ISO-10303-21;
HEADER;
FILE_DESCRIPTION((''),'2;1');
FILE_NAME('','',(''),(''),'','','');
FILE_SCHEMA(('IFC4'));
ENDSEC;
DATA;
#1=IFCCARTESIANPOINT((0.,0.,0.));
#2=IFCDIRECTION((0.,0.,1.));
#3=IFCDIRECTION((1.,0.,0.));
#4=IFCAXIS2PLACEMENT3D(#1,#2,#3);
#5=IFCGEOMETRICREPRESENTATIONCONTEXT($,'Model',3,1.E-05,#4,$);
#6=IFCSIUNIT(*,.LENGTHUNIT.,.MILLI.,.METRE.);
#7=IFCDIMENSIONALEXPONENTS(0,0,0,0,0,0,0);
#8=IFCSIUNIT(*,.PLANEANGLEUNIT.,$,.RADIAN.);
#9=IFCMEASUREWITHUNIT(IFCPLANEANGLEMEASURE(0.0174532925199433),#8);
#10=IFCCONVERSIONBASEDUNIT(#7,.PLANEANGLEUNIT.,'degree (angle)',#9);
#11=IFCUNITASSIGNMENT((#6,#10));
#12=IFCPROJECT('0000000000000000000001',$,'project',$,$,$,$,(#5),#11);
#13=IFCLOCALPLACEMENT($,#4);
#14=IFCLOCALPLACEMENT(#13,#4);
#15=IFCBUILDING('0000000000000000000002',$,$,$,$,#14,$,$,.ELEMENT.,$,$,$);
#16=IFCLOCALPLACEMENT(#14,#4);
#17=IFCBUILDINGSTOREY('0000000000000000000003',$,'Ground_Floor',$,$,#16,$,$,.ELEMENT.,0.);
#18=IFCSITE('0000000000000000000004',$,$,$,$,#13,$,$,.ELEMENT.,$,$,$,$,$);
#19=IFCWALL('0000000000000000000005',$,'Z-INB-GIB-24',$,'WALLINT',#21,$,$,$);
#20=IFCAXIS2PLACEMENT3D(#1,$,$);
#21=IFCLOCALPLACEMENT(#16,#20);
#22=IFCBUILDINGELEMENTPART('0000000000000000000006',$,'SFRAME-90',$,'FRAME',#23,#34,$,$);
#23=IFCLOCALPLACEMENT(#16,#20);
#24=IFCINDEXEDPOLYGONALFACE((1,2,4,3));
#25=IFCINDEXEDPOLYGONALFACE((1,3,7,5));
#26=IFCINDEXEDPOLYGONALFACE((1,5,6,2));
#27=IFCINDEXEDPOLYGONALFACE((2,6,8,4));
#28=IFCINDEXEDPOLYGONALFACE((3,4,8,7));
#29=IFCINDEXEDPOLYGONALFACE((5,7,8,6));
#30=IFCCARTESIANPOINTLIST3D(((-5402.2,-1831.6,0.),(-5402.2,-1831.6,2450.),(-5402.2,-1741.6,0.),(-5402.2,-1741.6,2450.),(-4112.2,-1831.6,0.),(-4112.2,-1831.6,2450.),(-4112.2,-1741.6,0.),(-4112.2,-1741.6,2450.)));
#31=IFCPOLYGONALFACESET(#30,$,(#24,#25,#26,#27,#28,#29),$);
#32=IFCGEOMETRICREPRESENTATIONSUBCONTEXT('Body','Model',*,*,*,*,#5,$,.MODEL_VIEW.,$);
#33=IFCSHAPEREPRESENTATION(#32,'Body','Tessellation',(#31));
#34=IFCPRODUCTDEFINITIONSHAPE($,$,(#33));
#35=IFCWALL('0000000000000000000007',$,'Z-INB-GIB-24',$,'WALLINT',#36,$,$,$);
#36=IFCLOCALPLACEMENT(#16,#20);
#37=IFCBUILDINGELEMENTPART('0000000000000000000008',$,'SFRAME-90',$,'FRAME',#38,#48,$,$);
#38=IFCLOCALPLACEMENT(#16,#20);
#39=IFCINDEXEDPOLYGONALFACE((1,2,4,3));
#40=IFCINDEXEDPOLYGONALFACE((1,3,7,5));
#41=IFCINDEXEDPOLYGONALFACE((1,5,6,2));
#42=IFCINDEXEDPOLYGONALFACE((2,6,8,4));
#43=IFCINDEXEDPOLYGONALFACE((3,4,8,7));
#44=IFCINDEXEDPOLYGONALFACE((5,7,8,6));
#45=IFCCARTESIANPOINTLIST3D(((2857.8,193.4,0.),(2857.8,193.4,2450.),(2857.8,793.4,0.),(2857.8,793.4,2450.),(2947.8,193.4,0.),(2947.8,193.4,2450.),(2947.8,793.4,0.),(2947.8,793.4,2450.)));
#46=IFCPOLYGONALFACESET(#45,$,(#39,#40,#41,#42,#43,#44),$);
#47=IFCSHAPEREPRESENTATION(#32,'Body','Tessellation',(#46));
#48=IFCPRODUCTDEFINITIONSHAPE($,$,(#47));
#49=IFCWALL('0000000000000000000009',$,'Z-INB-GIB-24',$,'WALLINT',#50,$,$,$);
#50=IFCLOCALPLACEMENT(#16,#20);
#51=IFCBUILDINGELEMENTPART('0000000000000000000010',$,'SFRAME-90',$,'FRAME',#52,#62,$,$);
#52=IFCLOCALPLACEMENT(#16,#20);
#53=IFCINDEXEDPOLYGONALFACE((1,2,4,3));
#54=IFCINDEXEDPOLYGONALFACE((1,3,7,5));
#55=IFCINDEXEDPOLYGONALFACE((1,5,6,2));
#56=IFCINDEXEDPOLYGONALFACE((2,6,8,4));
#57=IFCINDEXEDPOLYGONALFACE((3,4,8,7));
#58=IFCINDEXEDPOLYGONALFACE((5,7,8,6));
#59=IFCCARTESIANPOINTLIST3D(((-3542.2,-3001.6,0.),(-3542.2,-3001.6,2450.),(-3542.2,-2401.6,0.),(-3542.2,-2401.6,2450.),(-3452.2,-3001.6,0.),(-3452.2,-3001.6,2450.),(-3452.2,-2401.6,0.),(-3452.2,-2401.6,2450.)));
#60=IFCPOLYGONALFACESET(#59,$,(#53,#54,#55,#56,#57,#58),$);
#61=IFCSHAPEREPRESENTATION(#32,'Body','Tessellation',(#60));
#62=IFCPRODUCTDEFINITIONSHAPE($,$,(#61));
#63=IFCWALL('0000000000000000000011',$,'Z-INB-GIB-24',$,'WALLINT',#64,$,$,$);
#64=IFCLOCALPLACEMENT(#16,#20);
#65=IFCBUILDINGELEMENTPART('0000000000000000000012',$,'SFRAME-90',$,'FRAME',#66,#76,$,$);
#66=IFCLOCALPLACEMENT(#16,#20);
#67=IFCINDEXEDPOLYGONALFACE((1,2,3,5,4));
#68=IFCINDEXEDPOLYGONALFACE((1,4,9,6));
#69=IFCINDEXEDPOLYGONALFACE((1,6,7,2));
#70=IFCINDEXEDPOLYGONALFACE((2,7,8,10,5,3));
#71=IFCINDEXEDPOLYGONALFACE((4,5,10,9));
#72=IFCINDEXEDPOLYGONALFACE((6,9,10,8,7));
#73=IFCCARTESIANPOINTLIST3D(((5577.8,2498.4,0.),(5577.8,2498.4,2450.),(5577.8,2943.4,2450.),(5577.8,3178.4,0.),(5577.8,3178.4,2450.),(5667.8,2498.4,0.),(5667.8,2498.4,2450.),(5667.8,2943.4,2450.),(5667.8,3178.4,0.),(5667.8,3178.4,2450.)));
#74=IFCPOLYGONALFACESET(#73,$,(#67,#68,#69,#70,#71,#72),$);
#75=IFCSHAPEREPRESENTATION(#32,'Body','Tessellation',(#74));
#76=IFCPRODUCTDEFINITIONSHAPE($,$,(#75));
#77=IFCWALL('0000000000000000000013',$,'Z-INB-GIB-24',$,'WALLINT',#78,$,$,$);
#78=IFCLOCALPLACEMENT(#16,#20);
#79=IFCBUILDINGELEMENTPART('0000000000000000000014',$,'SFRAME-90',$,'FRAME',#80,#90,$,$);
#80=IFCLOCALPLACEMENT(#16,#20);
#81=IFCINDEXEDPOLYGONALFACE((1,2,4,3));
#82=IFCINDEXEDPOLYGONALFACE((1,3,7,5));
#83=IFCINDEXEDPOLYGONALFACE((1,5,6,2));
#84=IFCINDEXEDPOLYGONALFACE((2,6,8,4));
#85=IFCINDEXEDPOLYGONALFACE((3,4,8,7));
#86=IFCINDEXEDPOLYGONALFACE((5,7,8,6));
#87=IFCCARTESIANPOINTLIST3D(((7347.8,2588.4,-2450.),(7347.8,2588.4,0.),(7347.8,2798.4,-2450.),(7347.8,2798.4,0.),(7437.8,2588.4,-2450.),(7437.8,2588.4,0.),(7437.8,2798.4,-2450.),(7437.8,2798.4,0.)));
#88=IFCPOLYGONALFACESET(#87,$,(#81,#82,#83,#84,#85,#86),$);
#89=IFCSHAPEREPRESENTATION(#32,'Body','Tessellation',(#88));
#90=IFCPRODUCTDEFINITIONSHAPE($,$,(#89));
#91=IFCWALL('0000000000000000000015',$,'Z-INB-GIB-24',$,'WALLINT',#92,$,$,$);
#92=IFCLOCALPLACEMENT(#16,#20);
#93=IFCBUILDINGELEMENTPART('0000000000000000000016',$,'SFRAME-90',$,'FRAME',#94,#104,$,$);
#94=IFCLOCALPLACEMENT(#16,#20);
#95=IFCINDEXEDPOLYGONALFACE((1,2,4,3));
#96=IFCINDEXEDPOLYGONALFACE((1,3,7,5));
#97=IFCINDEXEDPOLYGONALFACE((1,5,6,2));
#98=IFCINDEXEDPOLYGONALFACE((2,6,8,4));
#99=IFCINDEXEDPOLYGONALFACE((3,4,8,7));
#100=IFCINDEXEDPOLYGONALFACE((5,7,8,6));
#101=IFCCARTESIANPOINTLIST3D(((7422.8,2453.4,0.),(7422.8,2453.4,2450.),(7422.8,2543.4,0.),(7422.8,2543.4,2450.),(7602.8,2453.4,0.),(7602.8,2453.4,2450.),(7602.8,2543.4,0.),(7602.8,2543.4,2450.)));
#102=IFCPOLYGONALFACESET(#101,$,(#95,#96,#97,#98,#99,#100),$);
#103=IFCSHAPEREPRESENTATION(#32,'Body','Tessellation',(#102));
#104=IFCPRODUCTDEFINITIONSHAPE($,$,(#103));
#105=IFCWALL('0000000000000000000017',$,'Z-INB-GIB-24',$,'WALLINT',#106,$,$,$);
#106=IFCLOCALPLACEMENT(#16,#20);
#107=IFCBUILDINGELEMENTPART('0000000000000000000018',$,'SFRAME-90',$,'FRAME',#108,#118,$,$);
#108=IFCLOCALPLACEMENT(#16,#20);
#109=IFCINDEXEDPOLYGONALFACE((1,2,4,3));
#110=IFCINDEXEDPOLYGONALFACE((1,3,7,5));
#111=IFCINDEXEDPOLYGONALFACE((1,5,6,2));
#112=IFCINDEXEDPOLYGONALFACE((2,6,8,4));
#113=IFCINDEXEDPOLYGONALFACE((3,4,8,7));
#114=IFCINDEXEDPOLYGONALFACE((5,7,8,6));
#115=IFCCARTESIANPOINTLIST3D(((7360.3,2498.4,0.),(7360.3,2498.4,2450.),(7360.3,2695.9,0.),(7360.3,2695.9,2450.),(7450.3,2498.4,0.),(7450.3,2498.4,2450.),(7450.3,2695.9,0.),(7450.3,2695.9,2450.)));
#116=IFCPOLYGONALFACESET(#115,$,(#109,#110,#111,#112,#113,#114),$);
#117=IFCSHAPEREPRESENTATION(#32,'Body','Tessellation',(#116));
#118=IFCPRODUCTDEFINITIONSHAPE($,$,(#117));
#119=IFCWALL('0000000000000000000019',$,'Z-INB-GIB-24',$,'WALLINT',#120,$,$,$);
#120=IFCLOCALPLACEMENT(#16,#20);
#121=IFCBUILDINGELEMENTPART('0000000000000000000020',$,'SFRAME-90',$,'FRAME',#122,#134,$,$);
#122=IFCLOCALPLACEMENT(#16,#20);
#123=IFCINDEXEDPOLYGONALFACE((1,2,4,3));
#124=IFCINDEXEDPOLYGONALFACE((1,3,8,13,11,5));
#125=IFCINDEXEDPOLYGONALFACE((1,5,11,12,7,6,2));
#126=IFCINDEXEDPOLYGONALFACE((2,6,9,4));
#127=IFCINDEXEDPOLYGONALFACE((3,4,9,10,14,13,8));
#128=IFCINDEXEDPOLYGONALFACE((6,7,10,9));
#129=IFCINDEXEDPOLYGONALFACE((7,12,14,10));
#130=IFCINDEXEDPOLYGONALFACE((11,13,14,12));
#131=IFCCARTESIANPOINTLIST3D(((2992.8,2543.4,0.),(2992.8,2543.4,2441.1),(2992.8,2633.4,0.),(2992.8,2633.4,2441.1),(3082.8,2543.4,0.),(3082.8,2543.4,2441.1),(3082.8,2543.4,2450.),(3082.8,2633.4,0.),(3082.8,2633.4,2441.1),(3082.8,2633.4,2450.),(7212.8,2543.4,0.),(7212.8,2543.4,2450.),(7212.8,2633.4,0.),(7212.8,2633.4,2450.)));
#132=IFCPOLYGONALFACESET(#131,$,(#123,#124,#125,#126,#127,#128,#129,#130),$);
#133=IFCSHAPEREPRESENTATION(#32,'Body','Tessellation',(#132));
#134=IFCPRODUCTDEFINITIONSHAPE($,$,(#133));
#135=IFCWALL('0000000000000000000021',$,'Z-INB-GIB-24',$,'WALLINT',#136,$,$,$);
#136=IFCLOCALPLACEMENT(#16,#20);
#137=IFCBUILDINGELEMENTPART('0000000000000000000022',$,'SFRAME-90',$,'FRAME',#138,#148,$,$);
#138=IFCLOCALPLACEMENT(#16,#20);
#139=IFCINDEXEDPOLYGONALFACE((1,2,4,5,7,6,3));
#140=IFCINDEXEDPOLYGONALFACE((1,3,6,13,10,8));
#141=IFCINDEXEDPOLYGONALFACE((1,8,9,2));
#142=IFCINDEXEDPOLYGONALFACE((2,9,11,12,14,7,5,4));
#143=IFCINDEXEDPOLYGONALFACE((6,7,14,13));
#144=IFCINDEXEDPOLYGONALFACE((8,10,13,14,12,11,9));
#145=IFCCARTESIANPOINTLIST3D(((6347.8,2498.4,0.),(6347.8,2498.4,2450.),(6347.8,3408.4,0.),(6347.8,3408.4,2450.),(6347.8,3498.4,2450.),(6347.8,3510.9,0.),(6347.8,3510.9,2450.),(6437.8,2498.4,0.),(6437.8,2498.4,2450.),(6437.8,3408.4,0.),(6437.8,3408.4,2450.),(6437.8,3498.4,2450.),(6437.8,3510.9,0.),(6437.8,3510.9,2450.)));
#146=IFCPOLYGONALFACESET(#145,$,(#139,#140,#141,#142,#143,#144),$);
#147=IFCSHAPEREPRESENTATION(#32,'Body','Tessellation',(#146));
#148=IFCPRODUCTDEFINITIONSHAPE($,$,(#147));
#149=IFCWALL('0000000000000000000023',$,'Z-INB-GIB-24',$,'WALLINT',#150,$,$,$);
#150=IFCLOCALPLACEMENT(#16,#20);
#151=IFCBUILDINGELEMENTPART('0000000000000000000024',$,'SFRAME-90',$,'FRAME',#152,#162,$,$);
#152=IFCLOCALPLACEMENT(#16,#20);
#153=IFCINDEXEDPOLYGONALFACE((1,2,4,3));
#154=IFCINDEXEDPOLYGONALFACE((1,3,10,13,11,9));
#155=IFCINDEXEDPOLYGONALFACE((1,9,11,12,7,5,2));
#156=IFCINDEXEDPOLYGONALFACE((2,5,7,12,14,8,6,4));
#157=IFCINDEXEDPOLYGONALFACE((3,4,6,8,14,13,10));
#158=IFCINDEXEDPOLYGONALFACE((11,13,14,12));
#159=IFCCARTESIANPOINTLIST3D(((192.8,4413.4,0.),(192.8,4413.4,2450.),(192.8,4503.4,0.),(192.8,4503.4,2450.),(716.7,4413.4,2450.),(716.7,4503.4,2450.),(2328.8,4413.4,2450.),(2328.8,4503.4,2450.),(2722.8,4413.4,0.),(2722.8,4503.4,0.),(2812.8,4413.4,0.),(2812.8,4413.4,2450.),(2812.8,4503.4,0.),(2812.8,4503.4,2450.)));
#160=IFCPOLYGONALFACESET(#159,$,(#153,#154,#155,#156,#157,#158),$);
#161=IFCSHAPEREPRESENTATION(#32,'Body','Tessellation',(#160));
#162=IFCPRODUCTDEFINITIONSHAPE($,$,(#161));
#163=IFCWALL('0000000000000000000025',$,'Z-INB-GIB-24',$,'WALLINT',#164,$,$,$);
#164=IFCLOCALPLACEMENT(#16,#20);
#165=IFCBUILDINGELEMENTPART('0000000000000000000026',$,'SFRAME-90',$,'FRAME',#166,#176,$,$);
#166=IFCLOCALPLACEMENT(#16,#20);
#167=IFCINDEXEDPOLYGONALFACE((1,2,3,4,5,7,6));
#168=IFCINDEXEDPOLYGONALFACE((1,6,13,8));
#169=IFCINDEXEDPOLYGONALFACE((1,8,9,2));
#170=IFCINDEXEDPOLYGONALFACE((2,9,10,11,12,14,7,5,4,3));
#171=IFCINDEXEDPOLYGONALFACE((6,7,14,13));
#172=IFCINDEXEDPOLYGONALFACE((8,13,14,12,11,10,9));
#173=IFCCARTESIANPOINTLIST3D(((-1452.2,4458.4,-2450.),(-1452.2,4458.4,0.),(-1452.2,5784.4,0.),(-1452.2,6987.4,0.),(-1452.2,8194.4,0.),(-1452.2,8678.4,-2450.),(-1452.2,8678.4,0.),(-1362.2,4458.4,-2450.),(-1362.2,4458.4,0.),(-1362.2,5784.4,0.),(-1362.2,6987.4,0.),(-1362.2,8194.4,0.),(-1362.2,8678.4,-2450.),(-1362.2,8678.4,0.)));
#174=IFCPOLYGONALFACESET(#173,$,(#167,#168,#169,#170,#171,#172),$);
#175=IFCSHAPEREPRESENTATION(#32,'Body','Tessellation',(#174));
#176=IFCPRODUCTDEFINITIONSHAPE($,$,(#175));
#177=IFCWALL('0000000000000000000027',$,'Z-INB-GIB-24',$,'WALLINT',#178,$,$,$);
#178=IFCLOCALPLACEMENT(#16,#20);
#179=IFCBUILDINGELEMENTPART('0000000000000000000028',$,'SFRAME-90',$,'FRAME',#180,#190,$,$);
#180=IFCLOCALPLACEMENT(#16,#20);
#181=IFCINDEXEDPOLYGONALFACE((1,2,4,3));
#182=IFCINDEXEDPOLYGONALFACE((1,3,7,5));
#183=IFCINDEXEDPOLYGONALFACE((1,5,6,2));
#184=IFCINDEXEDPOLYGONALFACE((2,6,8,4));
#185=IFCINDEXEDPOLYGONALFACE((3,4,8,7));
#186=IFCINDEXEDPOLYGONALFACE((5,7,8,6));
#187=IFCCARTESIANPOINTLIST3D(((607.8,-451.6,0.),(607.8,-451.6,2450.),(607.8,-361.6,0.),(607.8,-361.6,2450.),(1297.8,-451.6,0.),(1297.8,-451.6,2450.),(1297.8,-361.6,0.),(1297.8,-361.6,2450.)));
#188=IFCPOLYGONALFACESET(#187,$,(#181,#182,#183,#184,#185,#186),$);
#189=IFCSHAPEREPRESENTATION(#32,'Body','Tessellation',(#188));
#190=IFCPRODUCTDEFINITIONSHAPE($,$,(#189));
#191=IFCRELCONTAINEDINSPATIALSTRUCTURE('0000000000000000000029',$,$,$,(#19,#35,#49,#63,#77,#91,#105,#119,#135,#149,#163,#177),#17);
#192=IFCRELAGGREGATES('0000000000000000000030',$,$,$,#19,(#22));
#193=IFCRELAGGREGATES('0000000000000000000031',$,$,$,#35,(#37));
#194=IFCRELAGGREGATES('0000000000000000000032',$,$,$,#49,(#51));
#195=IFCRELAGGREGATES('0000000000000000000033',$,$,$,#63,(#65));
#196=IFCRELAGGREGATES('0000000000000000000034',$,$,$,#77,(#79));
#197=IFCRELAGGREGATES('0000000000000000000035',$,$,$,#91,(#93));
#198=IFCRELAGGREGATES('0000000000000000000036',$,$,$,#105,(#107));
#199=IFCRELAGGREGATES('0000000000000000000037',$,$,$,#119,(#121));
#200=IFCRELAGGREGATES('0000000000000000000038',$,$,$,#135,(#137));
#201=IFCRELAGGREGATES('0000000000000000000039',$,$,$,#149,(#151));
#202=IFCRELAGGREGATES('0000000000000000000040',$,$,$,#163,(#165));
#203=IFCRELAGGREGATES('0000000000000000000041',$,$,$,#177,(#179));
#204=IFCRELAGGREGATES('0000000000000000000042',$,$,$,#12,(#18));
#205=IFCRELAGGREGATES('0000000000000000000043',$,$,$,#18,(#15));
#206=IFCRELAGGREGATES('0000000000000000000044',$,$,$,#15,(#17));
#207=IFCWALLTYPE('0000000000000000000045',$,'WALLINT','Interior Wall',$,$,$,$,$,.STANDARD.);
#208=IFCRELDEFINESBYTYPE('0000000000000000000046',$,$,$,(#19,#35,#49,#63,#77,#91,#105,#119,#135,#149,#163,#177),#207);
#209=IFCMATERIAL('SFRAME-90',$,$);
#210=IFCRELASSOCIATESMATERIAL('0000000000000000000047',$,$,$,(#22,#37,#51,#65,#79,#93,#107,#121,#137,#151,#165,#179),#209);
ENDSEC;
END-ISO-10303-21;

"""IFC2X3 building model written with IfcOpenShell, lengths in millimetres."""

from ifc_helpers import new_model, entity, si_unit, converted_unit, frame, origin_with_axes, place, context, subcontext, project, spatial, polyline, segment, composite_curve, outline, extrude, material, type_object, element, aggregate, save


model = new_model("IFC2X3")

# Units and contexts
model_context = context("Model", 3, precision=1e-05, world=origin_with_axes())
body_context = subcontext(model_context, "Body", "Model", "MODEL_VIEW")
ifc_project = project(units=[si_unit("LENGTHUNIT", "METRE", prefix="MILLI"), converted_unit("PLANEANGLEUNIT", "degree (angle)", entity("IfcPlaneAngleMeasure", 0.0174532925199433), si_unit("PLANEANGLEUNIT", "RADIAN"), dimensions=[0, 0, 0, 0, 0, 0, 0])], contexts=[model_context])

# Site, building, storey
site_placement = place(None, origin_with_axes())
site = spatial("IfcSite", under=ifc_project, at=site_placement, CompositionType="ELEMENT")
building_placement = place(site_placement, origin_with_axes())
building = spatial("IfcBuilding", under=site, at=building_placement, CompositionType="ELEMENT")
storey_placement = place(building_placement, origin_with_axes())
storey = spatial("IfcBuildingStorey", under=building, at=storey_placement, Name="Ground_Floor", CompositionType="ELEMENT", Elevation=0.0)

# Walls, building element parts
wall_type = type_object("IfcWallType", Name="WALLINT", Description="Interior Wall", PredefinedType="STANDARD")
ifc_material = material(Name="SFRAME-90")
wall_1_placement = place(storey_placement, frame((-4112.2, -1786.6, 2450.0), z_axis=(0.0, 0.0, 1.0), x_axis=(-1.0, 0.0, 0.0)))
wall_1 = element("IfcWall", 1, at=wall_1_placement, inside=storey, type_object=wall_type, Name="Z-INB-GIB-24", ObjectType="WALLINT")
building_element_part_1_placement = place(wall_1_placement, origin_with_axes())
building_element_part_1 = element("IfcBuildingElementPart", 2, at=building_element_part_1_placement, material=ifc_material, Name="SFRAME-90", ObjectType="FRAME", context=body_context, shape_type="SweptSolid", body=[
    extrude(outline(composite_curve([segment(polyline([(0.0, 2450.0), (0.0, 0.0), (1290.0, 0.0), (1290.0, 2450.0), (0.0, 2450.0)]), True, "CONTINUOUS")], self_intersect=False)), frame((0.0, -45.0, 0.0), z_axis=(0.0, 1.0, 0.0), x_axis=(1.0, 0.0, 0.0)), (0.0, 0.0, 1.0), 90.0),
])
aggregate(wall_1, [building_element_part_1])
wall_2_placement = place(storey_placement, frame((2902.8, 193.4, 2450.0), z_axis=(0.0, 0.0, 1.0), x_axis=(0.0, 1.0, 0.0)))
wall_2 = element("IfcWall", 3, at=wall_2_placement, inside=storey, type_object=wall_type, Name="Z-INB-GIB-24", ObjectType="WALLINT")
building_element_part_2_placement = place(wall_2_placement, origin_with_axes())
building_element_part_2 = element("IfcBuildingElementPart", 4, at=building_element_part_2_placement, material=ifc_material, Name="SFRAME-90", ObjectType="FRAME", context=body_context, shape_type="SweptSolid", body=[
    extrude(outline(composite_curve([segment(polyline([(0.0, 0.0), (600.0, 0.0), (600.0, 2450.0), (0.0, 2450.0), (0.0, 0.0)]), True, "CONTINUOUS")], self_intersect=False)), frame((0.0, -45.0, 0.0), z_axis=(0.0, 1.0, 0.0), x_axis=(1.0, 0.0, 0.0)), (0.0, 0.0, 1.0), 90.0),
])
aggregate(wall_2, [building_element_part_2])
wall_3_placement = place(storey_placement, frame((-3497.2, -3001.6, 2450.0), z_axis=(0.0, 0.0, 1.0), x_axis=(0.0, 1.0, 0.0)))
wall_3 = element("IfcWall", 5, at=wall_3_placement, inside=storey, type_object=wall_type, Name="Z-INB-GIB-24", ObjectType="WALLINT")
building_element_part_3_placement = place(wall_3_placement, origin_with_axes())
building_element_part_3 = element("IfcBuildingElementPart", 6, at=building_element_part_3_placement, material=ifc_material, Name="SFRAME-90", ObjectType="FRAME", context=body_context, shape_type="SweptSolid", body=[
    extrude(outline(composite_curve([segment(polyline([(0.0, 0.0), (600.0, 0.0), (600.0, 2450.0), (0.0, 2450.0), (0.0, 0.0)]), True, "CONTINUOUS")], self_intersect=False)), frame((0.0, -45.0, 0.0), z_axis=(0.0, 1.0, 0.0), x_axis=(1.0, 0.0, 0.0)), (0.0, 0.0, 1.0), 90.0),
])
aggregate(wall_3, [building_element_part_3])
wall_4_placement = place(storey_placement, frame((5622.8, 2498.4, 2450.0), z_axis=(0.0, 0.0, 1.0), x_axis=(0.0, 1.0, 0.0)))
wall_4 = element("IfcWall", 7, at=wall_4_placement, inside=storey, type_object=wall_type, Name="Z-INB-GIB-24", ObjectType="WALLINT")
building_element_part_4_placement = place(wall_4_placement, origin_with_axes())
building_element_part_4 = element("IfcBuildingElementPart", 8, at=building_element_part_4_placement, material=ifc_material, Name="SFRAME-90", ObjectType="FRAME", context=body_context, shape_type="SweptSolid", body=[
    extrude(outline(composite_curve([segment(polyline([(0.0, 0.0), (0.0, 2450.0), (680.0, 2450.0), (680.0, 0.0), (445.0, 0.0), (0.0, 0.0)]), True, "CONTINUOUS")], self_intersect=False)), frame((0.0, -45.0, 0.0), z_axis=(0.0, 1.0, 0.0), x_axis=(1.0, 0.0, 0.0)), (0.0, 0.0, 1.0), 90.0),
])
aggregate(wall_4, [building_element_part_4])
wall_5_placement = place(storey_placement, frame((7392.8, 2588.4, 0.0), z_axis=(0.0, 0.0, 1.0), x_axis=(0.0, 1.0, 0.0)))
wall_5 = element("IfcWall", 9, at=wall_5_placement, inside=storey, type_object=wall_type, Name="Z-INB-GIB-24", ObjectType="WALLINT")
building_element_part_5_placement = place(wall_5_placement, origin_with_axes())
building_element_part_5 = element("IfcBuildingElementPart", 10, at=building_element_part_5_placement, material=ifc_material, Name="SFRAME-90", ObjectType="FRAME", context=body_context, shape_type="SweptSolid", body=[
    extrude(outline(composite_curve([segment(polyline([(0.0, 2450.0), (0.0, 0.0), (210.0, 0.0), (210.0, 2450.0), (0.0, 2450.0)]), True, "CONTINUOUS")], self_intersect=False)), frame((0.0, -45.0, 0.0), z_axis=(0.0, 1.0, 0.0), x_axis=(1.0, 0.0, 0.0)), (0.0, 0.0, 1.0), 90.0),
])
aggregate(wall_5, [building_element_part_5])
wall_6_placement = place(storey_placement, frame((7602.8, 2498.4, 2450.0), z_axis=(0.0, 0.0, 1.0), x_axis=(-1.0, 0.0, 0.0)))
wall_6 = element("IfcWall", 11, at=wall_6_placement, inside=storey, type_object=wall_type, Name="Z-INB-GIB-24", ObjectType="WALLINT")
building_element_part_6_placement = place(wall_6_placement, origin_with_axes())
building_element_part_6 = element("IfcBuildingElementPart", 12, at=building_element_part_6_placement, material=ifc_material, Name="SFRAME-90", ObjectType="FRAME", context=body_context, shape_type="SweptSolid", body=[
    extrude(outline(composite_curve([segment(polyline([(0.0, 2450.0), (0.0, 0.0), (180.0, 0.0), (180.0, 2450.0), (0.0, 2450.0)]), True, "CONTINUOUS")], self_intersect=False)), frame((0.0, -45.0, 0.0), z_axis=(0.0, 1.0, 0.0), x_axis=(1.0, 0.0, 0.0)), (0.0, 0.0, 1.0), 90.0),
])
aggregate(wall_6, [building_element_part_6])
wall_7_placement = place(storey_placement, frame((7405.3, 2498.4, 2450.0), z_axis=(0.0, 0.0, 1.0), x_axis=(0.0, 1.0, 0.0)))
wall_7 = element("IfcWall", 13, at=wall_7_placement, inside=storey, type_object=wall_type, Name="Z-INB-GIB-24", ObjectType="WALLINT")
building_element_part_7_placement = place(wall_7_placement, origin_with_axes())
building_element_part_7 = element("IfcBuildingElementPart", 14, at=building_element_part_7_placement, material=ifc_material, Name="SFRAME-90", ObjectType="FRAME", context=body_context, shape_type="SweptSolid", body=[
    extrude(outline(composite_curve([segment(polyline([(0.0, 0.0), (197.5, 0.0), (197.5, 2450.0), (0.0, 2450.0), (0.0, 0.0)]), True, "CONTINUOUS")], self_intersect=False)), frame((0.0, -45.0, 0.0), z_axis=(0.0, 1.0, 0.0), x_axis=(1.0, 0.0, 0.0)), (0.0, 0.0, 1.0), 90.0),
])
aggregate(wall_7, [building_element_part_7])
wall_8_placement = place(storey_placement, frame((7302.8, 2588.4, 2450.0), z_axis=(0.0, 0.0, 1.0), x_axis=(-1.0, 0.0, 0.0)))
wall_8 = element("IfcWall", 15, at=wall_8_placement, inside=storey, type_object=wall_type, Name="Z-INB-GIB-24", ObjectType="WALLINT")
building_element_part_8_placement = place(wall_8_placement, origin_with_axes())
building_element_part_8 = element("IfcBuildingElementPart", 16, at=building_element_part_8_placement, material=ifc_material, Name="SFRAME-90", ObjectType="FRAME", context=body_context, shape_type="SweptSolid", body=[
    extrude(outline(composite_curve([segment(polyline([(0.0, 2450.0), (90.0, 2450.0), (90.0, 0.0), (0.0, 0.0), (4220.0, 0.0), (4220.0, 8.9), (4310.0, 8.9), (4310.0, 2450.0), (4220.0, 2450.0), (0.0, 2450.0)]), True, "CONTINUOUS")], self_intersect=False)), frame((0.0, -45.0, 0.0), z_axis=(0.0, 1.0, 0.0), x_axis=(1.0, 0.0, 0.0)), (0.0, 0.0, 1.0), 90.0),
])
aggregate(wall_8, [building_element_part_8])
wall_9_placement = place(storey_placement, frame((6392.8, 2498.4, 2450.0), z_axis=(0.0, 0.0, 1.0), x_axis=(0.0, 1.0, 0.0)))
wall_9 = element("IfcWall", 17, at=wall_9_placement, inside=storey, type_object=wall_type, Name="Z-INB-GIB-24", ObjectType="WALLINT")
building_element_part_9_placement = place(wall_9_placement, origin_with_axes())
building_element_part_9 = element("IfcBuildingElementPart", 18, at=building_element_part_9_placement, material=ifc_material, Name="SFRAME-90", ObjectType="FRAME", context=body_context, shape_type="SweptSolid", body=[
    extrude(outline(composite_curve([segment(polyline([(0.0, 0.0), (0.0, 2450.0), (910.0, 2450.0), (1012.5, 2450.0), (1012.5, 0.0), (1000.0, 0.0), (910.0, 0.0), (0.0, 0.0)]), True, "CONTINUOUS")], self_intersect=False)), frame((0.0, -45.0, 0.0), z_axis=(0.0, 1.0, 0.0), x_axis=(1.0, 0.0, 0.0)), (0.0, 0.0, 1.0), 90.0),
])
aggregate(wall_9, [building_element_part_9])
wall_10_placement = place(storey_placement, frame((2812.8, 4458.4, 2450.0), z_axis=(0.0, 0.0, 1.0), x_axis=(-1.0, 0.0, 0.0)))
wall_10 = element("IfcWall", 19, at=wall_10_placement, inside=storey, type_object=wall_type, Name="Z-INB-GIB-24", ObjectType="WALLINT")
building_element_part_10_placement = place(wall_10_placement, origin_with_axes())
building_element_part_10 = element("IfcBuildingElementPart", 20, at=building_element_part_10_placement, material=ifc_material, Name="SFRAME-90", ObjectType="FRAME", context=body_context, shape_type="SweptSolid", body=[
    extrude(outline(composite_curve([segment(polyline([(0.0, 0.0), (0.0, 2450.0), (90.0, 2450.0), (2620.0, 2450.0), (2620.0, 0.0), (2096.0, 0.0), (484.0, 0.0), (0.0, 0.0)]), True, "CONTINUOUS")], self_intersect=False)), frame((0.0, -45.0, 0.0), z_axis=(0.0, 1.0, 0.0), x_axis=(1.0, 0.0, 0.0)), (0.0, 0.0, 1.0), 90.0),
])
aggregate(wall_10, [building_element_part_10])
wall_11_placement = place(storey_placement, frame((-1407.2, 4458.4, 0.0), z_axis=(0.0, 0.0, 1.0), x_axis=(0.0, 1.0, 0.0)))
wall_11 = element("IfcWall", 21, at=wall_11_placement, inside=storey, type_object=wall_type, Name="Z-INB-GIB-24", ObjectType="WALLINT")
building_element_part_11_placement = place(wall_11_placement, origin_with_axes())
building_element_part_11 = element("IfcBuildingElementPart", 22, at=building_element_part_11_placement, material=ifc_material, Name="SFRAME-90", ObjectType="FRAME", context=body_context, shape_type="SweptSolid", body=[
    extrude(outline(composite_curve([segment(polyline([(0.0, 0.0), (0.0, 2450.0), (4220.0, 2450.0), (4220.0, 0.0), (3736.0, 0.0), (2529.0, 0.0), (1326.0, 0.0), (0.0, 0.0)]), True, "CONTINUOUS")], self_intersect=False)), frame((0.0, -45.0, 0.0), z_axis=(0.0, 1.0, 0.0), x_axis=(1.0, 0.0, 0.0)), (0.0, 0.0, 1.0), 90.0),
])
aggregate(wall_11, [building_element_part_11])
wall_12_placement = place(storey_placement, frame((1297.8, -406.6, 2450.0), z_axis=(0.0, 0.0, 1.0), x_axis=(-1.0, 0.0, 0.0)))
wall_12 = element("IfcWall", 23, at=wall_12_placement, inside=storey, type_object=wall_type, Name="Z-INB-GIB-24", ObjectType="WALLINT")
building_element_part_12_placement = place(wall_12_placement, origin_with_axes())
building_element_part_12 = element("IfcBuildingElementPart", 24, at=building_element_part_12_placement, material=ifc_material, Name="SFRAME-90", ObjectType="FRAME", context=body_context, shape_type="SweptSolid", body=[
    extrude(outline(composite_curve([segment(polyline([(0.0, 2450.0), (0.0, 0.0), (690.0, 0.0), (690.0, 2450.0), (0.0, 2450.0)]), True, "CONTINUOUS")], self_intersect=False)), frame((0.0, -45.0, 0.0), z_axis=(0.0, 1.0, 0.0), x_axis=(1.0, 0.0, 0.0)), (0.0, 0.0, 1.0), 90.0),
])
aggregate(wall_12, [building_element_part_12])

save(model, "model.ifc")
